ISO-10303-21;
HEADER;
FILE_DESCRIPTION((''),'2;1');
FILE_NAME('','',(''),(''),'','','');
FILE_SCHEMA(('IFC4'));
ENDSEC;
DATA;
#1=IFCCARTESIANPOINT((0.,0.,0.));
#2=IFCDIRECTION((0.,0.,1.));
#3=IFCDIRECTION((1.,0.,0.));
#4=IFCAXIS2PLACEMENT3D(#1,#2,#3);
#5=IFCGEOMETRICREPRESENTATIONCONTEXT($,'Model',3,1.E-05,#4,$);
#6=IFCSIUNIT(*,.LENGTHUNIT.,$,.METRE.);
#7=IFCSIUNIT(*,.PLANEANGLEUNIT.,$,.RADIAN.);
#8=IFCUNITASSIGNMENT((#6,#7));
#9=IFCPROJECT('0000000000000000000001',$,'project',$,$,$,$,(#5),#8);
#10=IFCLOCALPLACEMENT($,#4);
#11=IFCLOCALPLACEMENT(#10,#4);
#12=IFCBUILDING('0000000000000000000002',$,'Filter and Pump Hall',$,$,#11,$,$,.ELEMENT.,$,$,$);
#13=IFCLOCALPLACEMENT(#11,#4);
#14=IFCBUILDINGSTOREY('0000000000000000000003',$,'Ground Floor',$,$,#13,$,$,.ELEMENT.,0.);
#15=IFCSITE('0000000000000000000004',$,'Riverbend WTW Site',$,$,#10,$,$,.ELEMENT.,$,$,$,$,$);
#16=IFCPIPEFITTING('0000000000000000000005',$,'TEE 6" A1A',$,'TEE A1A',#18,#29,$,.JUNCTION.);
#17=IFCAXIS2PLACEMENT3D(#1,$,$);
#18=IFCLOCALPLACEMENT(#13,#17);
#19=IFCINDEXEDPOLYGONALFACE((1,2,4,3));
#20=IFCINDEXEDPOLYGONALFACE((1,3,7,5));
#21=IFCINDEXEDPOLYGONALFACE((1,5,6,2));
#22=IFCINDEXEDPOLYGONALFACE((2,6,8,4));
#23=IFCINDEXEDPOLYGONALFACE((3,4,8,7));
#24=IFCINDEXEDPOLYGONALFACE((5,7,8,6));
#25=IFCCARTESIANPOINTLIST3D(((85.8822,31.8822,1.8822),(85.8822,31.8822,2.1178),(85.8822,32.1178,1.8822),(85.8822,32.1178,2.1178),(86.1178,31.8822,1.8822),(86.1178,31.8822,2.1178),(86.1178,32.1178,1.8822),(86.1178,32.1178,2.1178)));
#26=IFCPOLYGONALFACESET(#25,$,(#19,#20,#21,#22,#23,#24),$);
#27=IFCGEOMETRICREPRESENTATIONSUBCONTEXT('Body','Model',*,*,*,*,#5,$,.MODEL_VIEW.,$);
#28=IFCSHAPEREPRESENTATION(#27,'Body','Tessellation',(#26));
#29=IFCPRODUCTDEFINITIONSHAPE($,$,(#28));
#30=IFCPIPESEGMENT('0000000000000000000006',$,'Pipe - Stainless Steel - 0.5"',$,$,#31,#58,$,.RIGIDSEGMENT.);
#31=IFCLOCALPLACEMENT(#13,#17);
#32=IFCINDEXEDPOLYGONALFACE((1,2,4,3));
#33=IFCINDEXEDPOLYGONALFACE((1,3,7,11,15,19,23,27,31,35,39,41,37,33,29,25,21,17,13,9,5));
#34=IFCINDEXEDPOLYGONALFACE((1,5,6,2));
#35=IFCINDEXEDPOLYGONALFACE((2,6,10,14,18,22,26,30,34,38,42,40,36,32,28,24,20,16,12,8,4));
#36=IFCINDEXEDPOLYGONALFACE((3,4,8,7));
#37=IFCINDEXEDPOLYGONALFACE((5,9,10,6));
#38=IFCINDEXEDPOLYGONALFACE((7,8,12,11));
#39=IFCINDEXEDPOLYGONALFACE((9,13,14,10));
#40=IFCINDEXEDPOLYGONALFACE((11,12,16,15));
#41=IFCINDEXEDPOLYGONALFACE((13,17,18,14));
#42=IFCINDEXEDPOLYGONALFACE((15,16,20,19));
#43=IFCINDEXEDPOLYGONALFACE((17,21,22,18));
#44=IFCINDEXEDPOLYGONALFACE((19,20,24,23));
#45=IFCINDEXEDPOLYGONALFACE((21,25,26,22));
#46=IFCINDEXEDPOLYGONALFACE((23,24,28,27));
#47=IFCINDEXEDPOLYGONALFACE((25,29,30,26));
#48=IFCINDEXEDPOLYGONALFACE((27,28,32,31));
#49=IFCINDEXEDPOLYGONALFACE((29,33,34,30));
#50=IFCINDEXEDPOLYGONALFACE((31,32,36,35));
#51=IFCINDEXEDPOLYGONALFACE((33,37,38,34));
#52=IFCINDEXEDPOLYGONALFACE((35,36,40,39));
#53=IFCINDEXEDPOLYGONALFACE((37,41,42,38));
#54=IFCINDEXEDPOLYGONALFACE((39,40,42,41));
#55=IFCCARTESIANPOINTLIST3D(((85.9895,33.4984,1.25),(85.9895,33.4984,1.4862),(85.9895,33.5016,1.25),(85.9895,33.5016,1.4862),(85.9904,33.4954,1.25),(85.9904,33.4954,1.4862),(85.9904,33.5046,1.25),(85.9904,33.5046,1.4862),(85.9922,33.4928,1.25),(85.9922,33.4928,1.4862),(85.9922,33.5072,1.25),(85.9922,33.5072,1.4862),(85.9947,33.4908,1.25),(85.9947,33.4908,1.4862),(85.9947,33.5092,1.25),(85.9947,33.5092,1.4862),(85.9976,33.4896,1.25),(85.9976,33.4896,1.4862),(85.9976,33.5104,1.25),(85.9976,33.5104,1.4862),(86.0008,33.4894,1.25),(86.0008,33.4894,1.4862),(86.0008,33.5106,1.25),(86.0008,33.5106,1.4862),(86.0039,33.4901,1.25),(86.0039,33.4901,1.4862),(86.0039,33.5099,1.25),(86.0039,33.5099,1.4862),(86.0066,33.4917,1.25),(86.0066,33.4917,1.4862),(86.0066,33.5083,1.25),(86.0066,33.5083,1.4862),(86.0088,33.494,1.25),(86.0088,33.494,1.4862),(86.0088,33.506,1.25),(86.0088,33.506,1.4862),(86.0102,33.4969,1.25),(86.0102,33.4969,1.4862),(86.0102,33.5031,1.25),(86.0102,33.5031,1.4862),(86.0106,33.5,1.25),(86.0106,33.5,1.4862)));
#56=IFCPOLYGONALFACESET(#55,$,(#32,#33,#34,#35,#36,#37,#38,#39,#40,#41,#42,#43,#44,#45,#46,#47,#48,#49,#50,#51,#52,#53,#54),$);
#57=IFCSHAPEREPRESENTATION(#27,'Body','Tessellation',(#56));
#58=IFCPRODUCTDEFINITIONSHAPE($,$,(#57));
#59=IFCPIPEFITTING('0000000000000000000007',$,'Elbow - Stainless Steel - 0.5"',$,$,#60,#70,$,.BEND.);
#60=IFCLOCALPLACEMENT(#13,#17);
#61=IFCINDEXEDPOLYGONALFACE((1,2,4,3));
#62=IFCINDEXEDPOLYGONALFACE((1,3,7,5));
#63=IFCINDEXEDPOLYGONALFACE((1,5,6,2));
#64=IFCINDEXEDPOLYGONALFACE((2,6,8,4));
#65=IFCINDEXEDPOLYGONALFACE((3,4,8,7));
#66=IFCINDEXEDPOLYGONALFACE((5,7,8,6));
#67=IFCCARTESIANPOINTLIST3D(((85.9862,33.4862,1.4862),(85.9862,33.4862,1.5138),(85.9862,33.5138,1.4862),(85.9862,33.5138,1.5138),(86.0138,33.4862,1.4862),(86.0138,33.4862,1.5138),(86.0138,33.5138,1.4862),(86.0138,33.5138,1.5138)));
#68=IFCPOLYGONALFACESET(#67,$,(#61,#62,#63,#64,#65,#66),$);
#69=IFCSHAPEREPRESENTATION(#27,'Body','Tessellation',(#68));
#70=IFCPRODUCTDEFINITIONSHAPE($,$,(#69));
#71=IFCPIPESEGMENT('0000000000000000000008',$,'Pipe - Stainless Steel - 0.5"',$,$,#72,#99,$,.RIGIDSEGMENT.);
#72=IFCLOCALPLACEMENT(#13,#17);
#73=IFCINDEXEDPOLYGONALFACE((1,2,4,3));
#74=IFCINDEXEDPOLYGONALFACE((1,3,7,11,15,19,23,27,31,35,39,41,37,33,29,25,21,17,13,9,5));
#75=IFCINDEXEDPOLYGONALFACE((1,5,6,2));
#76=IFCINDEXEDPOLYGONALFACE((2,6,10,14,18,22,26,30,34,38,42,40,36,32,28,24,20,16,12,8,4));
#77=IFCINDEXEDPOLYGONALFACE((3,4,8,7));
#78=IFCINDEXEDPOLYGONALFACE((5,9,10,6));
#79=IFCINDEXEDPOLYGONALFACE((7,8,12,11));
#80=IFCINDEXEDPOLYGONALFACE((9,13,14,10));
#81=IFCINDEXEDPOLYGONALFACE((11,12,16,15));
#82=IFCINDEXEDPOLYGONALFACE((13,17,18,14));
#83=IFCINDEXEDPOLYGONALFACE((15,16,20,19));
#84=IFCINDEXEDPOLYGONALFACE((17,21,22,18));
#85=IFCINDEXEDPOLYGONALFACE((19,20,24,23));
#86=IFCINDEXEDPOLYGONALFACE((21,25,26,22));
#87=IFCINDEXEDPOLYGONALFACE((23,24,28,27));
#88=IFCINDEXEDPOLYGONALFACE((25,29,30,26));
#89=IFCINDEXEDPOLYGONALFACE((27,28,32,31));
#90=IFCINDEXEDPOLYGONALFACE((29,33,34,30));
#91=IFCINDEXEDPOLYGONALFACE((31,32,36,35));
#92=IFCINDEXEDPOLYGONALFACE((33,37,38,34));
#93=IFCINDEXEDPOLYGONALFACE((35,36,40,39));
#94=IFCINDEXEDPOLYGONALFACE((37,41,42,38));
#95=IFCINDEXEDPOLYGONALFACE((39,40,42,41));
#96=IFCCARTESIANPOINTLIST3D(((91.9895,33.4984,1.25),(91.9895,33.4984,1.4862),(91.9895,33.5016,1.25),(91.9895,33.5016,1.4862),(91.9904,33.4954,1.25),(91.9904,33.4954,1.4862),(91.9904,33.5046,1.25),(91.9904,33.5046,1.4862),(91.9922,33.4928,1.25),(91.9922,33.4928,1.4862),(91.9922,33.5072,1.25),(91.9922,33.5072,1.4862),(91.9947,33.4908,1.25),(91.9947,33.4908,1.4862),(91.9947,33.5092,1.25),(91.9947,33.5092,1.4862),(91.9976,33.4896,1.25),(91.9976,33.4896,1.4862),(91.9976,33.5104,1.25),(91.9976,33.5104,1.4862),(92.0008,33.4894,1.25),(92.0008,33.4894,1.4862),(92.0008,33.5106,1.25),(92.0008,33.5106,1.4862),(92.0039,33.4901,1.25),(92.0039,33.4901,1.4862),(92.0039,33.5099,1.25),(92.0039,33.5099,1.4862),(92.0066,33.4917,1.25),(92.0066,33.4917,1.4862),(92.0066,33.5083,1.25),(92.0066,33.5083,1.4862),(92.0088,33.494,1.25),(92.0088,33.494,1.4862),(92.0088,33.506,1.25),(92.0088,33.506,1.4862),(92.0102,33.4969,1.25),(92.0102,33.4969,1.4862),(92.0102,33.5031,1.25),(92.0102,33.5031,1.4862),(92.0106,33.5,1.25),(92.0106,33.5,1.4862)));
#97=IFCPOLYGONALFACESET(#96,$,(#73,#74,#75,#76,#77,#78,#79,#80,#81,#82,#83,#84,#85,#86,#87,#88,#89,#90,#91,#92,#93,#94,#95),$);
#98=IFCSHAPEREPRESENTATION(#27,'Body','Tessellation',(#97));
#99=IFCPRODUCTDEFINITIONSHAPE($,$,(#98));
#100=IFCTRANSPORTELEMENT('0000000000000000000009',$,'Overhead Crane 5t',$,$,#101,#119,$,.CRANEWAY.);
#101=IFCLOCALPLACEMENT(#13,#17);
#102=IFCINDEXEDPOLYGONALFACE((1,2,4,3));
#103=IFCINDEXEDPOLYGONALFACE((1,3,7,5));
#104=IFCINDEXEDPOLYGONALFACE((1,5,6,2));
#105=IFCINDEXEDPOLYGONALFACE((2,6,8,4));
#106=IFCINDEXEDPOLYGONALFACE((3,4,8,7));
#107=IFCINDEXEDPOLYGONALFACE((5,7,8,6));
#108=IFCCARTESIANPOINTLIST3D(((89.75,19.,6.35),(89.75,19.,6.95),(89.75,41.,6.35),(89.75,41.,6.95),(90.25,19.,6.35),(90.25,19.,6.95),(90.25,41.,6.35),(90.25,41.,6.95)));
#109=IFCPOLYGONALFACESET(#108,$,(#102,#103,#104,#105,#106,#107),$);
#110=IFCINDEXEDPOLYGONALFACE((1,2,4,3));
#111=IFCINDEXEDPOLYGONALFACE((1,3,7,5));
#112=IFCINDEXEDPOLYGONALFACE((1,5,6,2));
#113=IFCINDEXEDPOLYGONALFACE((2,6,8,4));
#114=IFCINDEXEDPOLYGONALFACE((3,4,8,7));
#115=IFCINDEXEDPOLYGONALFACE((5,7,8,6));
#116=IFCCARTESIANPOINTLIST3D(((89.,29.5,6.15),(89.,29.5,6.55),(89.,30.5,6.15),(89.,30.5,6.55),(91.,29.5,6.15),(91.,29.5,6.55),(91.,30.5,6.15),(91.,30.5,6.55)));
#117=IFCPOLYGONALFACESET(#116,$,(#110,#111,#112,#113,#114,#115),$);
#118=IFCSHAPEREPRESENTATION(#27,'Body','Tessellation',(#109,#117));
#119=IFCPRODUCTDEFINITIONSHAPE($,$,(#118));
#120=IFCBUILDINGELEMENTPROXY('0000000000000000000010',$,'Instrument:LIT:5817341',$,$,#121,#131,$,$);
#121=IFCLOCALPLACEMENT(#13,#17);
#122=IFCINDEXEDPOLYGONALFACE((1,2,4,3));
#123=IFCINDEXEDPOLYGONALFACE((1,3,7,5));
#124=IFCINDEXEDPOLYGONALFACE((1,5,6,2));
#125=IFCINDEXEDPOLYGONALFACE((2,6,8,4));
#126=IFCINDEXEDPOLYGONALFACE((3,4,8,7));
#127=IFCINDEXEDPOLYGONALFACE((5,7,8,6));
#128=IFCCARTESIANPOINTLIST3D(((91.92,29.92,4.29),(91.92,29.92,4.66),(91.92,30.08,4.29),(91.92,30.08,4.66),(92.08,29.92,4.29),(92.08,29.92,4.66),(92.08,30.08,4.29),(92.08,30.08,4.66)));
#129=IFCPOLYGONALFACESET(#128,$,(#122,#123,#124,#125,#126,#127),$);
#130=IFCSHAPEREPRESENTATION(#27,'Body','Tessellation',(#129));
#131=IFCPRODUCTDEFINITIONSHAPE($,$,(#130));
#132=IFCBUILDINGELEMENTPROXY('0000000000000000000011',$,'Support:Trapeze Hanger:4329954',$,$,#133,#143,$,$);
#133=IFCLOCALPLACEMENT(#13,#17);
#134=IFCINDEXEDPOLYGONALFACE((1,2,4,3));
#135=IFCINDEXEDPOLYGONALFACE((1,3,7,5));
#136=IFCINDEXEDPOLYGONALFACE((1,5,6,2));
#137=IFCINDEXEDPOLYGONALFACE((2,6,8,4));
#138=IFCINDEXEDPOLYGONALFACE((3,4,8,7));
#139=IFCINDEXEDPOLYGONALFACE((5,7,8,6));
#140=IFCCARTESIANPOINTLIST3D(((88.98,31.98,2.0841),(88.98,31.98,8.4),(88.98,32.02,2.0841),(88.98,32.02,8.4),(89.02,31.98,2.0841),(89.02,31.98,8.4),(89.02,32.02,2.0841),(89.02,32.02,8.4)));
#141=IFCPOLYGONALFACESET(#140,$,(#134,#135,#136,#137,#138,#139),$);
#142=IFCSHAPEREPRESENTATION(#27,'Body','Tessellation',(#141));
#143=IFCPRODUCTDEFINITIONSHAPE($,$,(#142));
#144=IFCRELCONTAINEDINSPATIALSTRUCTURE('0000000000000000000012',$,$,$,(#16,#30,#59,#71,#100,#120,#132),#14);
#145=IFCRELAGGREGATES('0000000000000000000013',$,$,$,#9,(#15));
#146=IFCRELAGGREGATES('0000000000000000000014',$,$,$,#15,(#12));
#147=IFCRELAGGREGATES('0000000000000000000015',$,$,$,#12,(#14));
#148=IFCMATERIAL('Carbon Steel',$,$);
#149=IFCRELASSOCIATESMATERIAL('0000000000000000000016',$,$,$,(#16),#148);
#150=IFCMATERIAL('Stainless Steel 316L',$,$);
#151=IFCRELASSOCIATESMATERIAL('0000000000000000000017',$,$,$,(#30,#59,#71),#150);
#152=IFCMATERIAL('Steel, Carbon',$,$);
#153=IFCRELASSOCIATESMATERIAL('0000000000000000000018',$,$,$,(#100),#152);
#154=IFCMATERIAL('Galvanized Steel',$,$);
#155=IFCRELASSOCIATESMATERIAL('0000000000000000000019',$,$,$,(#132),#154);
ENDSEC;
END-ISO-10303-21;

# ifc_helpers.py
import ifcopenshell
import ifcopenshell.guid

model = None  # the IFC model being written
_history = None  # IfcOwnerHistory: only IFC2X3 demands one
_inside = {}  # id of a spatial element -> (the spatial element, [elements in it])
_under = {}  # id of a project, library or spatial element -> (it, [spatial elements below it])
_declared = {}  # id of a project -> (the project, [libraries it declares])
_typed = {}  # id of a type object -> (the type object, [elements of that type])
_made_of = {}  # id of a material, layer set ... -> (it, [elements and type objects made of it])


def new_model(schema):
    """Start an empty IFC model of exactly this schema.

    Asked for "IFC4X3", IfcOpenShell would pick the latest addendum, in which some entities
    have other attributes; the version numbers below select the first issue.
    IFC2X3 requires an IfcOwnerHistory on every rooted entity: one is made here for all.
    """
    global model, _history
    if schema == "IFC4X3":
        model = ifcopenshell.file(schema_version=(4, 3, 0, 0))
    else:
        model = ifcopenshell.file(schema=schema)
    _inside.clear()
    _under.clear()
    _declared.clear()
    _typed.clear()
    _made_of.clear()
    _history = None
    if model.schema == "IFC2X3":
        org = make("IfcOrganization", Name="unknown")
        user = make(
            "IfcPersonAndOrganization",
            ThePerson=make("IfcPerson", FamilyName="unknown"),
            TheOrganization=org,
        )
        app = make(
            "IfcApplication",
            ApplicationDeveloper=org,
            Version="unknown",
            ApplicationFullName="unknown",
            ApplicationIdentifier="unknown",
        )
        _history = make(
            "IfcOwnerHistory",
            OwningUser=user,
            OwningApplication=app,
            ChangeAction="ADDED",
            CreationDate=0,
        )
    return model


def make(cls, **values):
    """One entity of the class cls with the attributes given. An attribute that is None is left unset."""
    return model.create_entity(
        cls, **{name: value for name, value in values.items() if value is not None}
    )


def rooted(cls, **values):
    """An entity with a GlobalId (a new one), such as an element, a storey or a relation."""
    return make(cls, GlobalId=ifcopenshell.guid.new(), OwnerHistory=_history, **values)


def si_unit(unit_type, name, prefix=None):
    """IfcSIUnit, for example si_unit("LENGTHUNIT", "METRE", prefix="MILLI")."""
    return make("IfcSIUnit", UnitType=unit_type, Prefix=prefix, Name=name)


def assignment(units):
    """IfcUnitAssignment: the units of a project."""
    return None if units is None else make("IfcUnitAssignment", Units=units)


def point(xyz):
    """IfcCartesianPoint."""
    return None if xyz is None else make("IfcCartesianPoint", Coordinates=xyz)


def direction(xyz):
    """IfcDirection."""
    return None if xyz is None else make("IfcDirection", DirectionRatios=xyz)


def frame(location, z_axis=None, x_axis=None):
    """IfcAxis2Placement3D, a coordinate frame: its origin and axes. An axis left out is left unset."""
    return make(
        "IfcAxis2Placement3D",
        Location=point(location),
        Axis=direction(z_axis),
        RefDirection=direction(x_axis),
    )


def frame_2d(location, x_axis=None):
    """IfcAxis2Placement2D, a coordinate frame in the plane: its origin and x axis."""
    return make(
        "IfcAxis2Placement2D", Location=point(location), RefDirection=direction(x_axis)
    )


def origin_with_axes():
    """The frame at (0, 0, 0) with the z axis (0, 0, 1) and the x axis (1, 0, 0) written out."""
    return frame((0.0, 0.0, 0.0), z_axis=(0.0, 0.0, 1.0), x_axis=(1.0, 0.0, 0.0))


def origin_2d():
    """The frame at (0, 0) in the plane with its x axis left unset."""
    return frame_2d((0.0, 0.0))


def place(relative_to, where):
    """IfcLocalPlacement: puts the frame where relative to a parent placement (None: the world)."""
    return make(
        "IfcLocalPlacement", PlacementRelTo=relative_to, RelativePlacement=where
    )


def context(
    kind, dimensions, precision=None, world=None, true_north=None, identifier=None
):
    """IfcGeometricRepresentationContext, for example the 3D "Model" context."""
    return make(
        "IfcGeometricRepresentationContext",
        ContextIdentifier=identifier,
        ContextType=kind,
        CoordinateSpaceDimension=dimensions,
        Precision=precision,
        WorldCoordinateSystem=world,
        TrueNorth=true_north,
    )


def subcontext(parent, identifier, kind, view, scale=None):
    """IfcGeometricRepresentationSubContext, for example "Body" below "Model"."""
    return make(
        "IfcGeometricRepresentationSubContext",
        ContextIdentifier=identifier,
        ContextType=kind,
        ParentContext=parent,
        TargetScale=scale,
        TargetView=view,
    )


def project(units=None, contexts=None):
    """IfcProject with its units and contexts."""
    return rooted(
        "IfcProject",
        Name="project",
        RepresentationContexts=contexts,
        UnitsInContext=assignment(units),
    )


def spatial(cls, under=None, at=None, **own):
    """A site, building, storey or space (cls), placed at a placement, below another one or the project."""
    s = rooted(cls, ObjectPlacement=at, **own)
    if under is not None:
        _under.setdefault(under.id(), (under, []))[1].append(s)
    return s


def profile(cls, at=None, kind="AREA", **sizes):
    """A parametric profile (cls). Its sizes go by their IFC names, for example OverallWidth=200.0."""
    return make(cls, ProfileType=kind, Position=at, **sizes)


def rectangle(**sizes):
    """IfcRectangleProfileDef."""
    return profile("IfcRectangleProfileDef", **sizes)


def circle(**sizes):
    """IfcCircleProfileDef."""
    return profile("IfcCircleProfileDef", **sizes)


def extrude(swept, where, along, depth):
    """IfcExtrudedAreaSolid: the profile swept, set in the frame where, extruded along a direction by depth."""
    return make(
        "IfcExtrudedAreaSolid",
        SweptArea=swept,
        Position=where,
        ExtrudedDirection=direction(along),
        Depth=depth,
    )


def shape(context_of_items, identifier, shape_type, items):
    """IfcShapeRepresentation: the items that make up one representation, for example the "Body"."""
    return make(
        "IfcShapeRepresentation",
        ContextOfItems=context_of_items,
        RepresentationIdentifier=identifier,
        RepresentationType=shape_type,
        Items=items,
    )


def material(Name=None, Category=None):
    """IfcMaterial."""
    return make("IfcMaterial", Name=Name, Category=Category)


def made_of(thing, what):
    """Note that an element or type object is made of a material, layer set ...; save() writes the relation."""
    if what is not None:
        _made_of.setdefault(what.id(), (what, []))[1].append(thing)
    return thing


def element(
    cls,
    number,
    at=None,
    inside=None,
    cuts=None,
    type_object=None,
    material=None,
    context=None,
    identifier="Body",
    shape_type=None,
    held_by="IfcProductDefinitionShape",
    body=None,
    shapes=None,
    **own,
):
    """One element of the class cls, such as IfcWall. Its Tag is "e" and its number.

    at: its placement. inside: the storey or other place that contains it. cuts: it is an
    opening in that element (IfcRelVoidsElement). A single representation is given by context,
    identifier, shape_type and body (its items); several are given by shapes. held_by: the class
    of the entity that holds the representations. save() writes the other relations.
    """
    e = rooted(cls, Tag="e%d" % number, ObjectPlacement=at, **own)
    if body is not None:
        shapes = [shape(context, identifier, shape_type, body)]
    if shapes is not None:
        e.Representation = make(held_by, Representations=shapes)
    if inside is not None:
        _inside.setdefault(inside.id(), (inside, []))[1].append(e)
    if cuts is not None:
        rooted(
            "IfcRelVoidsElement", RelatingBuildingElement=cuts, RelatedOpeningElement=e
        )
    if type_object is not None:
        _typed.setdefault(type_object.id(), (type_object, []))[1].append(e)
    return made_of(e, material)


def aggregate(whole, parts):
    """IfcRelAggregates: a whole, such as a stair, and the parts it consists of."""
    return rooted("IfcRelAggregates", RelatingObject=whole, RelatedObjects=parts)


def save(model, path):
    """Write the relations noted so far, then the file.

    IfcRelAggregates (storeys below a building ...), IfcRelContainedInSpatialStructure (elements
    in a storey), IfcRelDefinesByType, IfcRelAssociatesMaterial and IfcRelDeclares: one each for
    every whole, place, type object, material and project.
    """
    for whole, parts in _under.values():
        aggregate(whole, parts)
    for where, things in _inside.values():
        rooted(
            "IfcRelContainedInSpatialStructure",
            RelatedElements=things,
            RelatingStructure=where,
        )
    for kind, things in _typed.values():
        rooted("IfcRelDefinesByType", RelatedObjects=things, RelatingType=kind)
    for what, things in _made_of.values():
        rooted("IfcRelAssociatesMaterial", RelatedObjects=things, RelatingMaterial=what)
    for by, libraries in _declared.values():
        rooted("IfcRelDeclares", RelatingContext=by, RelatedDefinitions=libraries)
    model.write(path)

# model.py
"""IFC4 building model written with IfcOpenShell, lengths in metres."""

from ifc_helpers import new_model, si_unit, frame, origin_with_axes, origin_2d, place, context, subcontext, project, spatial, rectangle, circle, extrude, material, element, save


model = new_model("IFC4")

# Units and contexts
model_context = context("Model", 3, precision=1e-05, world=origin_with_axes())
body_context = subcontext(model_context, "Body", "Model", "MODEL_VIEW")
ifc_project = project(units=[si_unit("LENGTHUNIT", "METRE"), si_unit("PLANEANGLEUNIT", "RADIAN")], contexts=[model_context])

# Site, building, storey
site_placement = place(None, origin_with_axes())
site = spatial("IfcSite", under=ifc_project, at=site_placement, Name="Riverbend WTW Site", CompositionType="ELEMENT")
building_placement = place(site_placement, origin_with_axes())
building = spatial("IfcBuilding", under=site, at=building_placement, Name="Filter and Pump Hall", CompositionType="ELEMENT")
storey_placement = place(building_placement, origin_with_axes())
storey = spatial("IfcBuildingStorey", under=building, at=storey_placement, Name="Ground Floor", CompositionType="ELEMENT", Elevation=0.0)

# Shared definitions
ifc_material_1 = material(Name="Carbon Steel")

# Pipe fitting
for number, where, z_axis, x_axis, name in (
    (1, (86.0, 32.0, 2.0), (0.0, 0.0, 1.0), (1.0, 0.0, 0.0), "TEE 6\" A1A"),
):
    element("IfcPipeFitting", number, at=place(None, frame(where, z_axis=z_axis, x_axis=x_axis)), inside=storey, material=ifc_material_1, Name=name, ObjectType="TEE A1A", PredefinedType="JUNCTION", context=body_context, shape_type="SweptSolid", body=[
        extrude(rectangle(XDim=0.2356, YDim=0.2356, at=origin_2d()), frame((0.0, 0.0, -0.1178), z_axis=(0.0, 0.0, 1.0), x_axis=(1.0, 0.0, 0.0)), (0.0, 0.0, 1.0), 0.2356),
    ])

# Pipe segment
ifc_material_2 = material(Name="Stainless Steel 316L")
pipe_segment_1_placement = place(None, frame((86.0, 33.5, 1.4862), z_axis=(0.0, 0.0, 1.0), x_axis=(1.0, 0.0, 0.0)))
element("IfcPipeSegment", 2, at=pipe_segment_1_placement, inside=storey, material=ifc_material_2, Name="Pipe - Stainless Steel - 0.5\"", PredefinedType="RIGIDSEGMENT", context=body_context, shape_type="SweptSolid", body=[
    extrude(circle(Radius=0.0106, at=origin_2d()), frame((0.0, 0.0, 0.0), z_axis=(0.0, 0.0, -1.0), x_axis=(1.0, 0.0, 0.0)), (0.0, 0.0, 1.0), 0.2362),
])

# Pipe fitting
pipe_fitting_1_placement = place(None, frame((86.0, 33.5, 1.5), z_axis=(0.0, 0.0, 1.0), x_axis=(1.0, 0.0, 0.0)))
element("IfcPipeFitting", 3, at=pipe_fitting_1_placement, inside=storey, material=ifc_material_2, Name="Elbow - Stainless Steel - 0.5\"", PredefinedType="BEND", context=body_context, shape_type="SweptSolid", body=[
    extrude(rectangle(XDim=0.0277, YDim=0.0277, at=origin_2d()), frame((0.0, 0.0, -0.0138), z_axis=(0.0, 0.0, 1.0), x_axis=(1.0, 0.0, 0.0)), (0.0, 0.0, 1.0), 0.0277),
])

# Pipe segment
pipe_segment_2_placement = place(None, frame((92.0, 33.5, 1.4862), z_axis=(0.0, 0.0, 1.0), x_axis=(1.0, 0.0, 0.0)))
element("IfcPipeSegment", 4, at=pipe_segment_2_placement, inside=storey, material=ifc_material_2, Name="Pipe - Stainless Steel - 0.5\"", PredefinedType="RIGIDSEGMENT", context=body_context, shape_type="SweptSolid", body=[
    extrude(circle(Radius=0.0106, at=origin_2d()), frame((0.0, 0.0, 0.0), z_axis=(0.0, 0.0, -1.0), x_axis=(1.0, 0.0, 0.0)), (0.0, 0.0, 1.0), 0.2362),
])

# Transport element
ifc_material_3 = material(Name="Steel, Carbon")
transport_element_placement = place(None, frame((90.0, 30.0, 6.65), z_axis=(0.0, 0.0, 1.0), x_axis=(1.0, 0.0, 0.0)))
element("IfcTransportElement", 5, at=transport_element_placement, inside=storey, material=ifc_material_3, Name="Overhead Crane 5t", PredefinedType="CRANEWAY", context=body_context, shape_type="SweptSolid", body=[
    extrude(rectangle(XDim=0.5, YDim=22.0, at=origin_2d()), frame((0.0, 0.0, -0.3), z_axis=(0.0, 0.0, 1.0), x_axis=(1.0, 0.0, 0.0)), (0.0, 0.0, 1.0), 0.6),
    extrude(rectangle(XDim=2.0, YDim=1.0, at=origin_2d()), frame((0.0, 0.0, -0.5), z_axis=(0.0, 0.0, 1.0), x_axis=(1.0, 0.0, 0.0)), (0.0, 0.0, 1.0), 0.4),
])

# Building element proxies
proxy_1_placement = place(None, frame((92.0, 30.0, 4.475), z_axis=(0.0, 0.0, 1.0), x_axis=(1.0, 0.0, 0.0)))
element("IfcBuildingElementProxy", 6, at=proxy_1_placement, inside=storey, Name="Instrument:LIT:5817341", context=body_context, shape_type="SweptSolid", body=[
    extrude(rectangle(XDim=0.16, YDim=0.16, at=origin_2d()), frame((0.0, 0.0, -0.185), z_axis=(0.0, 0.0, 1.0), x_axis=(1.0, 0.0, 0.0)), (0.0, 0.0, 1.0), 0.37),
])
ifc_material_4 = material(Name="Galvanized Steel")
proxy_2_placement = place(None, frame((89.0, 32.0, 5.2421), z_axis=(0.0, 0.0, 1.0), x_axis=(1.0, 0.0, 0.0)))
element("IfcBuildingElementProxy", 7, at=proxy_2_placement, inside=storey, material=ifc_material_4, Name="Support:Trapeze Hanger:4329954", context=body_context, shape_type="SweptSolid", body=[
    extrude(rectangle(XDim=0.04, YDim=0.04, at=origin_2d()), frame((0.0, 0.0, -3.1579), z_axis=(0.0, 0.0, 1.0), x_axis=(1.0, 0.0, 0.0)), (0.0, 0.0, 1.0), 6.3159),
])

save(model, "model.ifc")
